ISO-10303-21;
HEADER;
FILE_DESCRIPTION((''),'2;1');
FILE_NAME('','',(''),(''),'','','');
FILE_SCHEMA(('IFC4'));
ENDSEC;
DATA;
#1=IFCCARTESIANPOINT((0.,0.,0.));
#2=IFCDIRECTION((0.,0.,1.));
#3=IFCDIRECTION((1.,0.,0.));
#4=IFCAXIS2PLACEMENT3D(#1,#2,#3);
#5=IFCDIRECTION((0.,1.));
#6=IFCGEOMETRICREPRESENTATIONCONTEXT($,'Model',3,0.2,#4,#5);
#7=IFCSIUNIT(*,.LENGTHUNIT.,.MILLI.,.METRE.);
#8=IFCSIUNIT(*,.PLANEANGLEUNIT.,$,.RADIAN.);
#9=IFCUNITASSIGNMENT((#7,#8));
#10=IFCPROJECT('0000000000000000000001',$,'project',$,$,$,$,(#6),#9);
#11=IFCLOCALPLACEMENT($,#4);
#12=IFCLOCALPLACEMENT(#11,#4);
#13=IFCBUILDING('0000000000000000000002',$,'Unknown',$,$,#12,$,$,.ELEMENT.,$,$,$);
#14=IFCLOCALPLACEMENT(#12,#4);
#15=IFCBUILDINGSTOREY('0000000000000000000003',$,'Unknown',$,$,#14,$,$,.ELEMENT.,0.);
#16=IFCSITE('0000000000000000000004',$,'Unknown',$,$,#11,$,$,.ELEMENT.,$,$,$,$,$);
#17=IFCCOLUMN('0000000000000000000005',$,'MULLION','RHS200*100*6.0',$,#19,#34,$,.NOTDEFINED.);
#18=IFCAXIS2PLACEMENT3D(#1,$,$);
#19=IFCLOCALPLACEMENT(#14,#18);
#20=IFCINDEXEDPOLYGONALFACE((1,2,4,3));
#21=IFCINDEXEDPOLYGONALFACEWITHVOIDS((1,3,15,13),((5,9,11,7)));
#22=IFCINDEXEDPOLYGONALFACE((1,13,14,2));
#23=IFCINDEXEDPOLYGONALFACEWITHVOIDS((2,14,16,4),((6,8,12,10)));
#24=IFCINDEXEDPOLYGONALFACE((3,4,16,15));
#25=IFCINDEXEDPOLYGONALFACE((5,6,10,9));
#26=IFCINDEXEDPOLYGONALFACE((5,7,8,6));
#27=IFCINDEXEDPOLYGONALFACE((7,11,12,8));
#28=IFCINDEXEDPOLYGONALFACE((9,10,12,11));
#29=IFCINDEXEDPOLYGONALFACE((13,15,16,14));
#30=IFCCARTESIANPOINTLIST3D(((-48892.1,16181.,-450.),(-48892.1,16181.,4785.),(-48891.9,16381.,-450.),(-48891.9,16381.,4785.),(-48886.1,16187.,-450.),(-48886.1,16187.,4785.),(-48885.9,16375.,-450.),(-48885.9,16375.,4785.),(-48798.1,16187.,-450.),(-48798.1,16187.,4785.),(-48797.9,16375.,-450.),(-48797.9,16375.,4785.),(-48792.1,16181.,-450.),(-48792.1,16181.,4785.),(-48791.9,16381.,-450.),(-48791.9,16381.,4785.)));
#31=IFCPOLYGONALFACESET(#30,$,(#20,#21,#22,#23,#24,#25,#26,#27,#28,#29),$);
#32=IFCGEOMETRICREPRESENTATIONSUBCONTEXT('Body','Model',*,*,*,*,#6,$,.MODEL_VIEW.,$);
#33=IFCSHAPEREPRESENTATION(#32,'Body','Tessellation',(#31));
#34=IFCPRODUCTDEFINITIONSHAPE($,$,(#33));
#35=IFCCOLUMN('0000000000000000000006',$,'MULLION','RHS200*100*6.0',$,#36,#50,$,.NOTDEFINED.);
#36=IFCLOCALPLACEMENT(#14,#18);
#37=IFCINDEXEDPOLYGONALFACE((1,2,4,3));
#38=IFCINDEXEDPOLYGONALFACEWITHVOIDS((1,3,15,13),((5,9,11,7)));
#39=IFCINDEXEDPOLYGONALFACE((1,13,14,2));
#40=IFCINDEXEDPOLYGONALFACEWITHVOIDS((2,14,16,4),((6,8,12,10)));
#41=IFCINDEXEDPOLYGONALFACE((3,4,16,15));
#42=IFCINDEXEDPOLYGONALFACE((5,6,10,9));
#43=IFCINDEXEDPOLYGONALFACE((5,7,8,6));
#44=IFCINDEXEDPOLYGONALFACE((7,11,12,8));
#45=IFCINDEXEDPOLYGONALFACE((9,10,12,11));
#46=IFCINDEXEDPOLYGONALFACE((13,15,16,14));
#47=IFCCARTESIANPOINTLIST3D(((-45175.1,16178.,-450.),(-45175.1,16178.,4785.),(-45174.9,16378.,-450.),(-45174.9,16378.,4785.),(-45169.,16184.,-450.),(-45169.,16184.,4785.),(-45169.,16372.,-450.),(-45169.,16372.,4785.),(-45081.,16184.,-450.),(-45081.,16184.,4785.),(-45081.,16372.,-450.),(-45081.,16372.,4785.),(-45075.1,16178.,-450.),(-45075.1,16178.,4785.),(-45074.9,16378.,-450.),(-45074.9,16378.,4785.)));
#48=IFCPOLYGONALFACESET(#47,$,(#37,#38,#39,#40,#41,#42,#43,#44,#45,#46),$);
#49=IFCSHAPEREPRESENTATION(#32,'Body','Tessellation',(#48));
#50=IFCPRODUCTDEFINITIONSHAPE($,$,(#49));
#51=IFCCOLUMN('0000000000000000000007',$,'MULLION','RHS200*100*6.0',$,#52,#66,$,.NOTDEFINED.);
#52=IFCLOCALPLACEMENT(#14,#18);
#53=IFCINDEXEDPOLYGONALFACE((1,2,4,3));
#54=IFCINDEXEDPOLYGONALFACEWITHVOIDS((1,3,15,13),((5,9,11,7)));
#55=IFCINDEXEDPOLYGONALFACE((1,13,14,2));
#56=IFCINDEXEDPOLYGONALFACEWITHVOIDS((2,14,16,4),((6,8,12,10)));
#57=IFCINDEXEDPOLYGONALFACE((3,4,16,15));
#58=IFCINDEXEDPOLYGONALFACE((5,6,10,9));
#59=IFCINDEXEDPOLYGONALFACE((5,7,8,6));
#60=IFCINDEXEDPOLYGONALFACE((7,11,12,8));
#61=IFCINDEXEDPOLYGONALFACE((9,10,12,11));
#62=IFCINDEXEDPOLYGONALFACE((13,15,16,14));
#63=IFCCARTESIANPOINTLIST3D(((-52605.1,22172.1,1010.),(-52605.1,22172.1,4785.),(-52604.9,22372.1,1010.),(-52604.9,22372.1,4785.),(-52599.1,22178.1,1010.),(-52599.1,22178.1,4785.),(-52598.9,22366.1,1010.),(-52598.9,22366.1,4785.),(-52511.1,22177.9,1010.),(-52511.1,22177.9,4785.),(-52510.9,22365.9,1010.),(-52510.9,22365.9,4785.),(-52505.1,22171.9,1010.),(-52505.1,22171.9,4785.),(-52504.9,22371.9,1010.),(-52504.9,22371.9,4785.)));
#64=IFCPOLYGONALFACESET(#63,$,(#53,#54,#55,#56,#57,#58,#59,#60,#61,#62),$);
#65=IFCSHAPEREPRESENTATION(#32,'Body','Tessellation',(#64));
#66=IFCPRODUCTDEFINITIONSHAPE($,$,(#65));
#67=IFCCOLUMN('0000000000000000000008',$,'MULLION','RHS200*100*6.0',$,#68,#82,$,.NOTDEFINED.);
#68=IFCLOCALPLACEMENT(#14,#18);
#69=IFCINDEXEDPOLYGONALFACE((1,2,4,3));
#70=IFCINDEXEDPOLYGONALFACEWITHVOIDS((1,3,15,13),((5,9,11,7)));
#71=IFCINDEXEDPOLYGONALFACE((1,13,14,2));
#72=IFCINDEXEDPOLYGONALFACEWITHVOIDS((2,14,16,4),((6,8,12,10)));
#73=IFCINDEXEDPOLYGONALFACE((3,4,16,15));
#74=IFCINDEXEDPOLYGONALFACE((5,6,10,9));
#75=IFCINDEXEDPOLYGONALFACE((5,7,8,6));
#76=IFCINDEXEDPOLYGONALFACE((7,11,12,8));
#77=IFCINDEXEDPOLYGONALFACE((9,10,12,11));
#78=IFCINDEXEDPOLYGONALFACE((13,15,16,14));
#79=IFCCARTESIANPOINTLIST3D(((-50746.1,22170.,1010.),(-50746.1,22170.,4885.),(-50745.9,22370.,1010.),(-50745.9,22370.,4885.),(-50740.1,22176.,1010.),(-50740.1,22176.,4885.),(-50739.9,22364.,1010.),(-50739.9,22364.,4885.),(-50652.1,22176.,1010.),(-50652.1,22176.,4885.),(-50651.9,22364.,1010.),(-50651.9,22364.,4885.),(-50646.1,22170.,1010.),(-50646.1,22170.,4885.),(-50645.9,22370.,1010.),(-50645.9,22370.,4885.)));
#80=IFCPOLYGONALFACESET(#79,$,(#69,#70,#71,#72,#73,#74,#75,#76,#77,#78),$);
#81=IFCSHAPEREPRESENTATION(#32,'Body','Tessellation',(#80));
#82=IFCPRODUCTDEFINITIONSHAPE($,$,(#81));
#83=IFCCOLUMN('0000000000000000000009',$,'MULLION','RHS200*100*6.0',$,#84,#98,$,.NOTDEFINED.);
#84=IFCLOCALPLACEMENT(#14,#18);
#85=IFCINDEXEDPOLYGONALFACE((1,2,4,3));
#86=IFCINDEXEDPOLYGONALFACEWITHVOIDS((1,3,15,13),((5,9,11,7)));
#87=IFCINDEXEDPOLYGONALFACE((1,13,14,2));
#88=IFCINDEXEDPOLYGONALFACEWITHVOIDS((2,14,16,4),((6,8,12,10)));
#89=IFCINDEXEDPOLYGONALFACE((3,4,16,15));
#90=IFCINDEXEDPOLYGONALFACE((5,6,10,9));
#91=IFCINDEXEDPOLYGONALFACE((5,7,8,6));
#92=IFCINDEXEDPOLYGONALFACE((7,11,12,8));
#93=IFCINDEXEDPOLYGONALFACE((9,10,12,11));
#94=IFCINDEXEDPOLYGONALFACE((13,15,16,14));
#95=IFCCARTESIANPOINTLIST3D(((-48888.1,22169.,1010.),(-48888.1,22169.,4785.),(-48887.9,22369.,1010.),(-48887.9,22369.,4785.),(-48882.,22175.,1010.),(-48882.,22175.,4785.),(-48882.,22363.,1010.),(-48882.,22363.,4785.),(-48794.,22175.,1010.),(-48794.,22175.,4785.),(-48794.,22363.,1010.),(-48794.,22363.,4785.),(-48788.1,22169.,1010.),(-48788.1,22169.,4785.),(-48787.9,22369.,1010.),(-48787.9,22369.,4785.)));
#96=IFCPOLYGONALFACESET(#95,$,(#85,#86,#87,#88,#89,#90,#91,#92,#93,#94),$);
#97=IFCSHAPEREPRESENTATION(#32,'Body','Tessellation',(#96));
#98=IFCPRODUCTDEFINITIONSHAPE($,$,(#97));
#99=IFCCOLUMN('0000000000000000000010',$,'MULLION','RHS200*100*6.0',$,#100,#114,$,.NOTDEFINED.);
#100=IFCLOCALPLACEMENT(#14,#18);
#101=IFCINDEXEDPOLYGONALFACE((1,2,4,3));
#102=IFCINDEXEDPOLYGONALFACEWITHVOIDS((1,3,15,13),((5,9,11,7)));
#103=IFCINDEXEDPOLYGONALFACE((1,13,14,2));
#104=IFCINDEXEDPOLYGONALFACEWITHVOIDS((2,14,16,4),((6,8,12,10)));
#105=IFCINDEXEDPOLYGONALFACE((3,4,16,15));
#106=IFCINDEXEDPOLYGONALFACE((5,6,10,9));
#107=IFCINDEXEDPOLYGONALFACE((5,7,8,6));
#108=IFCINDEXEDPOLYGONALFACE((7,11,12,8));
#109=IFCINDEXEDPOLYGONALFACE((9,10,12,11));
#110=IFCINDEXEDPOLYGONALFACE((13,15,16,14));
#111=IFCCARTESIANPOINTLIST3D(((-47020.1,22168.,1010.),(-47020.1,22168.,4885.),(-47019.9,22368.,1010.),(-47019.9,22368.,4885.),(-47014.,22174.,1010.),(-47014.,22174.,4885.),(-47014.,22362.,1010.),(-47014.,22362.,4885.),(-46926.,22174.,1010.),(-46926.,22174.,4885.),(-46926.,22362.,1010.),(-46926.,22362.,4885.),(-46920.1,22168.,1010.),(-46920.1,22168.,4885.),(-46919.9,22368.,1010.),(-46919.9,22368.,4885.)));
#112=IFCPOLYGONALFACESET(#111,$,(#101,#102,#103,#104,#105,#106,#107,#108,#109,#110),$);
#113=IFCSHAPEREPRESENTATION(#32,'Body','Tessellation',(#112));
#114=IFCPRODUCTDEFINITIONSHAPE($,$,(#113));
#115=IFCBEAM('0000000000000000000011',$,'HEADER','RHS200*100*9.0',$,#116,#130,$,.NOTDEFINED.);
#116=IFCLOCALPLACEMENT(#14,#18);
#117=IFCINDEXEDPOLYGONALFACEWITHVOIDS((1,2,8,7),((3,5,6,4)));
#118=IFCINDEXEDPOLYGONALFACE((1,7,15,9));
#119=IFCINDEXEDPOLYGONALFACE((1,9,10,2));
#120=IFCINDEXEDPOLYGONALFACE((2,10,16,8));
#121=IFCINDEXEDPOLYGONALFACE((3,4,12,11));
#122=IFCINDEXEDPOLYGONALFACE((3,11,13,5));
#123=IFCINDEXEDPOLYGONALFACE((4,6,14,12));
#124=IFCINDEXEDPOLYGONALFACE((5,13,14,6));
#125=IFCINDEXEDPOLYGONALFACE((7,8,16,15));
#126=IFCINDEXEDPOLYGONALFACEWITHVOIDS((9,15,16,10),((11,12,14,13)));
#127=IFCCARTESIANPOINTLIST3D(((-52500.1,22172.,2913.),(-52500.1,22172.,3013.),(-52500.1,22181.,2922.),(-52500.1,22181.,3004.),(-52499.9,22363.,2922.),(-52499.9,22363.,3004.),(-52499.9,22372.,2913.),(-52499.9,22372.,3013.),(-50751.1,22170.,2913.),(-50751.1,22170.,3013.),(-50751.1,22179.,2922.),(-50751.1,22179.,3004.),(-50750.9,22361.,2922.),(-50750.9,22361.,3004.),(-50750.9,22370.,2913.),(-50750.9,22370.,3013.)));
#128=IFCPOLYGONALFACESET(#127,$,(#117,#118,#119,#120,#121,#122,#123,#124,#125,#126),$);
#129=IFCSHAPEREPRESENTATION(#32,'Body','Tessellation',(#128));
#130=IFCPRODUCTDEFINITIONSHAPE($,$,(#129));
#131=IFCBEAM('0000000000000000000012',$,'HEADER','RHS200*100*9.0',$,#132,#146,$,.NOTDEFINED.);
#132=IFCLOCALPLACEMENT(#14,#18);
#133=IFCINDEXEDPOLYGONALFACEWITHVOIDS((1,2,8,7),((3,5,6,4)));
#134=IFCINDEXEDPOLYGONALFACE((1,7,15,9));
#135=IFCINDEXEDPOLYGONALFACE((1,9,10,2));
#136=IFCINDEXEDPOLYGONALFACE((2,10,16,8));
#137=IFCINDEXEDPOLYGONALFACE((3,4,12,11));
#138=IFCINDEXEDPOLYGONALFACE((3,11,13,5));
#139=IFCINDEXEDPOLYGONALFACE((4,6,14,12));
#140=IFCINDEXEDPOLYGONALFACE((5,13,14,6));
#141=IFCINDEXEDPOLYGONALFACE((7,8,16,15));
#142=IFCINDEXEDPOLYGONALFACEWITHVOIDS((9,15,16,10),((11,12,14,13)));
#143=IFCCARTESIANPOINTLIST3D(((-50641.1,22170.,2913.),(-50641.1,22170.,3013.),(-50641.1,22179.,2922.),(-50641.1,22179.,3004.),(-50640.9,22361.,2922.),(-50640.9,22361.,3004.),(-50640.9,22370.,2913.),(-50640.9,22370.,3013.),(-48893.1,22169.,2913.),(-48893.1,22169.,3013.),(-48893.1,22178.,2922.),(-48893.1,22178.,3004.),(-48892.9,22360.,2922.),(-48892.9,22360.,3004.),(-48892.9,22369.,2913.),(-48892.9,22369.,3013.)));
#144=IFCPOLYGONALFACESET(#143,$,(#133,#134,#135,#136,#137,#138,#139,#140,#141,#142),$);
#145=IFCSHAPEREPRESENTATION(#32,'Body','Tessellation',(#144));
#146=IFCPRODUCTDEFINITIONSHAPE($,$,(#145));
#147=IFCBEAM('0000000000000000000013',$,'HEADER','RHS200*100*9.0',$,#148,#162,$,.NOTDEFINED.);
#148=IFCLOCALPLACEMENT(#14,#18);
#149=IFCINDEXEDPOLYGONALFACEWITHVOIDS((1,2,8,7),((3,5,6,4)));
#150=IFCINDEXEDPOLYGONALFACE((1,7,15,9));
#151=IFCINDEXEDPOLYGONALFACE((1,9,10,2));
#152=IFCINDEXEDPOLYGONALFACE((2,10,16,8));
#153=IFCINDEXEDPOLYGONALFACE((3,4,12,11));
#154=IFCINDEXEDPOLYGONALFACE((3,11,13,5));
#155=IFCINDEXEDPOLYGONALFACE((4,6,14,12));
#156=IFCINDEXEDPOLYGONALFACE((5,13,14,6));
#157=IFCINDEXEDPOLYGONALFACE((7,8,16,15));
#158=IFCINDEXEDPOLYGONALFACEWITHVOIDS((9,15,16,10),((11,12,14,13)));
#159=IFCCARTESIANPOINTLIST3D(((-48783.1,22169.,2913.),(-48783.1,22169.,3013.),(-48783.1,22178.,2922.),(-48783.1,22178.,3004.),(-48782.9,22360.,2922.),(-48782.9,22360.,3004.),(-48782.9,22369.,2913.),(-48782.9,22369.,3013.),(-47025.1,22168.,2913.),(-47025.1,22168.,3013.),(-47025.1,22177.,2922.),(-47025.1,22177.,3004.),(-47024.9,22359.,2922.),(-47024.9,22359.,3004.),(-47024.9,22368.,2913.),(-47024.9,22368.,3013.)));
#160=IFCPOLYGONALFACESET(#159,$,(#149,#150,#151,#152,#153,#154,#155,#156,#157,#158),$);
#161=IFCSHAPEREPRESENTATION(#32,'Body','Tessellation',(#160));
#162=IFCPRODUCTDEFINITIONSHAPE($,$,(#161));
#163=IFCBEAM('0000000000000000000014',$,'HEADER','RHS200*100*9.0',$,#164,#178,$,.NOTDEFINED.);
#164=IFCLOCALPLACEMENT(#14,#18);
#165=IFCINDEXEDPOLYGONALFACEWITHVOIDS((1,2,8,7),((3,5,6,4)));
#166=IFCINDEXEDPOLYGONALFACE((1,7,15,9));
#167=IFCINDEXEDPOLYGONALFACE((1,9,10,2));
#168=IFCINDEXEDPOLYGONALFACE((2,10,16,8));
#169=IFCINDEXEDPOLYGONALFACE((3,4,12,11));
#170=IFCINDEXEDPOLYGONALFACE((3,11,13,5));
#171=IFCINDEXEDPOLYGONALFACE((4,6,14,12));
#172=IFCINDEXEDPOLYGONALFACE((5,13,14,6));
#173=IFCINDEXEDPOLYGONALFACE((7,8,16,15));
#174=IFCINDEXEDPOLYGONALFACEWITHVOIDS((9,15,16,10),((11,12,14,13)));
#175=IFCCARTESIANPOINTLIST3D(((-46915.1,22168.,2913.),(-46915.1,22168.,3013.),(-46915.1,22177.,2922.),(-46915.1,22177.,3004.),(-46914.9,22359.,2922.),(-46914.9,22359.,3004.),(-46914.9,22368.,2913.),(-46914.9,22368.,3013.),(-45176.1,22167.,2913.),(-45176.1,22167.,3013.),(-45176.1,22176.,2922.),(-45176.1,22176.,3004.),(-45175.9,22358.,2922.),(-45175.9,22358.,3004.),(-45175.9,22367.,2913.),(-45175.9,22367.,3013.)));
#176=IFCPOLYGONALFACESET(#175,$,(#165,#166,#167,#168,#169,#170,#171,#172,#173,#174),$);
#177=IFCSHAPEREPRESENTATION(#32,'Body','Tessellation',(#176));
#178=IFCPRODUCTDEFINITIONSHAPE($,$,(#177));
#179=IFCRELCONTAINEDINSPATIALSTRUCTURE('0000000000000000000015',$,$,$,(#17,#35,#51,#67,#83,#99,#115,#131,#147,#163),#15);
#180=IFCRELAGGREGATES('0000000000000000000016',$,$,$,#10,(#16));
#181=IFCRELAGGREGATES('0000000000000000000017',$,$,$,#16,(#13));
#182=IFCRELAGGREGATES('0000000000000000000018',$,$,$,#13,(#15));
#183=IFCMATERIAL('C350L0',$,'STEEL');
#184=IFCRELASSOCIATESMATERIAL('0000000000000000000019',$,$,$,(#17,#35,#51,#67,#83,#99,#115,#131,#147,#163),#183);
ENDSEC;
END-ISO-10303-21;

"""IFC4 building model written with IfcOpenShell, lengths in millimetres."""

from ifc_helpers import new_model, si_unit, direction, frame, origin_with_axes, place, context, subcontext, project, spatial, line, indexed_curve, outline, extrude, material, element, save


model = new_model("IFC4")

# Units and contexts
model_context = context("Model", 3, precision=0.2, world=origin_with_axes(), true_north=direction((0.0, 1.0)))
body_context = subcontext(model_context, "Body", "Model", "MODEL_VIEW")
ifc_project = project(units=[si_unit("LENGTHUNIT", "METRE", prefix="MILLI"), si_unit("PLANEANGLEUNIT", "RADIAN")], contexts=[model_context])

# Site, building, storey
site_placement = place(None, origin_with_axes())
site = spatial("IfcSite", under=ifc_project, at=site_placement, Name="Unknown", CompositionType="ELEMENT")
building_placement = place(site_placement, origin_with_axes())
building = spatial("IfcBuilding", under=site, at=building_placement, Name="Unknown", CompositionType="ELEMENT")
storey_placement = place(building_placement, origin_with_axes())
storey = spatial("IfcBuildingStorey", under=building, at=storey_placement, Name="Unknown", CompositionType="ELEMENT", Elevation=0.0)

# Columns
ifc_material_1 = material(Name="C350L0", Category="STEEL")
for number, where, z_axis, x_axis, name in (
    (1, (-48842.0, 16281.0, -450.0), (1.0, -0.000873, 0.0), (0.0, 0.0, 1.0), "MULLION"),
    (2, (-45125.0, 16278.0, -450.0), (1.0, -0.000524, 0.0), (0.0, 0.0, 1.0), "MULLION"),
):
    element("IfcColumn", number, at=place(storey_placement, frame(where, z_axis=z_axis, x_axis=x_axis)), inside=storey, material=ifc_material_1, Name=name, Description="RHS200*100*6.0", PredefinedType="NOTDEFINED", context=body_context, shape_type="SolidModel", body=[
        extrude(outline(indexed_curve([(-50.0, -100.0), (50.0, -100.0), (50.0, 100.0), (-50.0, 100.0)], segments=[line(1, 2, 3, 4, 1)]), holes=[indexed_curve([(-44.0, -94.0), (-44.0, 94.0), (44.0, 94.0), (44.0, -94.0)], segments=[line(1, 2, 3, 4, 1)])]), frame((0.0, 0.0, 0.0), z_axis=(-1.0, 0.0, 0.0), x_axis=(0.0, 0.0, 1.0)), (0.0, 0.0, -1.0), 5235.0),
    ])
column_1_placement = place(storey_placement, frame((-52555.0, 22272.0, 1010.0), z_axis=(0.999999, -0.001222, 0.0), x_axis=(0.0, 0.0, 1.0)))
element("IfcColumn", 3, at=column_1_placement, inside=storey, material=ifc_material_1, Name="MULLION", Description="RHS200*100*6.0", PredefinedType="NOTDEFINED", context=body_context, shape_type="SolidModel", body=[
    extrude(outline(indexed_curve([(-50.0, -100.0), (50.0, -100.0), (50.0, 100.0), (-50.0, 100.0)], segments=[line(1, 2, 3, 4, 1)]), holes=[indexed_curve([(-44.0, -94.0), (-44.0, 94.0), (44.0, 94.0), (44.0, -94.0)], segments=[line(1, 2, 3, 4, 1)])]), frame((0.0, 0.0, 0.0), z_axis=(-1.0, 0.0, 0.0), x_axis=(0.0, 0.0, 1.0)), (0.0, 0.0, -1.0), 3775.0),
])
column_2_placement = place(storey_placement, frame((-50696.0, 22270.0, 1010.0), z_axis=(1.0, -0.000873, 0.0), x_axis=(0.0, 0.0, 1.0)))
element("IfcColumn", 4, at=column_2_placement, inside=storey, material=ifc_material_1, Name="MULLION", Description="RHS200*100*6.0", PredefinedType="NOTDEFINED", context=body_context, shape_type="SolidModel", body=[
    extrude(outline(indexed_curve([(-50.0, -100.0), (50.0, -100.0), (50.0, 100.0), (-50.0, 100.0)], segments=[line(1, 2, 3, 4, 1)]), holes=[indexed_curve([(-44.0, -94.0), (-44.0, 94.0), (44.0, 94.0), (44.0, -94.0)], segments=[line(1, 2, 3, 4, 1)])]), frame((0.0, 0.0, 0.0), z_axis=(-1.0, 0.0, 0.0), x_axis=(0.0, 0.0, 1.0)), (0.0, 0.0, -1.0), 3875.0),
])
column_3_placement = place(storey_placement, frame((-48838.0, 22269.0, 1010.0), z_axis=(1.0, -0.000524, 0.0), x_axis=(0.0, 0.0, 1.0)))
element("IfcColumn", 5, at=column_3_placement, inside=storey, material=ifc_material_1, Name="MULLION", Description="RHS200*100*6.0", PredefinedType="NOTDEFINED", context=body_context, shape_type="SolidModel", body=[
    extrude(outline(indexed_curve([(-50.0, -100.0), (50.0, -100.0), (50.0, 100.0), (-50.0, 100.0)], segments=[line(1, 2, 3, 4, 1)]), holes=[indexed_curve([(-44.0, -94.0), (-44.0, 94.0), (44.0, 94.0), (44.0, -94.0)], segments=[line(1, 2, 3, 4, 1)])]), frame((0.0, 0.0, 0.0), z_axis=(-1.0, 0.0, 0.0), x_axis=(0.0, 0.0, 1.0)), (0.0, 0.0, -1.0), 3775.0),
])
column_4_placement = place(storey_placement, frame((-46970.0, 22268.0, 1010.0), z_axis=(1.0, -0.000524, 0.0), x_axis=(0.0, 0.0, 1.0)))
element("IfcColumn", 6, at=column_4_placement, inside=storey, material=ifc_material_1, Name="MULLION", Description="RHS200*100*6.0", PredefinedType="NOTDEFINED", context=body_context, shape_type="SolidModel", body=[
    extrude(outline(indexed_curve([(-50.0, -100.0), (50.0, -100.0), (50.0, 100.0), (-50.0, 100.0)], segments=[line(1, 2, 3, 4, 1)]), holes=[indexed_curve([(-44.0, -94.0), (-44.0, 94.0), (44.0, 94.0), (44.0, -94.0)], segments=[line(1, 2, 3, 4, 1)])]), frame((0.0, 0.0, 0.0), z_axis=(-1.0, 0.0, 0.0), x_axis=(0.0, 0.0, 1.0)), (0.0, 0.0, -1.0), 3875.0),
])

# Beams
beam_1_placement = place(storey_placement, frame((-50751.0, 22270.0, 2963.0), z_axis=(0.0, 0.0, 1.0), x_axis=(-0.999999, 0.001144, 0.0)))
element("IfcBeam", 7, at=beam_1_placement, inside=storey, material=ifc_material_1, Name="HEADER", Description="RHS200*100*9.0", PredefinedType="NOTDEFINED", context=body_context, shape_type="SolidModel", body=[
    extrude(outline(indexed_curve([(-50.0, -100.0), (50.0, -100.0), (50.0, 100.0), (-50.0, 100.0)], segments=[line(1, 2, 3, 4, 1)]), holes=[indexed_curve([(-41.0, -91.0), (-41.0, 91.0), (41.0, 91.0), (41.0, -91.0)], segments=[line(1, 2, 3, 4, 1)])]), frame((0.0, 0.0, 0.0), z_axis=(-1.0, 0.0, 0.0), x_axis=(0.0, 0.0, 1.0)), (0.0, 0.0, -1.0), 1749.0),
])
beam_2_placement = place(storey_placement, frame((-48893.0, 22269.0, 2963.0), z_axis=(0.0, 0.0, 1.0), x_axis=(-1.0, 0.000572, 0.0)))
element("IfcBeam", 8, at=beam_2_placement, inside=storey, material=ifc_material_1, Name="HEADER", Description="RHS200*100*9.0", PredefinedType="NOTDEFINED", context=body_context, shape_type="SolidModel", body=[
    extrude(outline(indexed_curve([(-50.0, -100.0), (50.0, -100.0), (50.0, 100.0), (-50.0, 100.0)], segments=[line(1, 2, 3, 4, 1)]), holes=[indexed_curve([(-41.0, -91.0), (-41.0, 91.0), (41.0, 91.0), (41.0, -91.0)], segments=[line(1, 2, 3, 4, 1)])]), frame((0.0, 0.0, 0.0), z_axis=(-1.0, 0.0, 0.0), x_axis=(0.0, 0.0, 1.0)), (0.0, 0.0, -1.0), 1748.0),
])
beam_3_placement = place(storey_placement, frame((-47025.0, 22268.0, 2963.0), z_axis=(0.0, 0.0, 1.0), x_axis=(-1.0, 0.000569, 0.0)))
element("IfcBeam", 9, at=beam_3_placement, inside=storey, material=ifc_material_1, Name="HEADER", Description="RHS200*100*9.0", PredefinedType="NOTDEFINED", context=body_context, shape_type="SolidModel", body=[
    extrude(outline(indexed_curve([(-50.0, -100.0), (50.0, -100.0), (50.0, 100.0), (-50.0, 100.0)], segments=[line(1, 2, 3, 4, 1)]), holes=[indexed_curve([(-41.0, -91.0), (-41.0, 91.0), (41.0, 91.0), (41.0, -91.0)], segments=[line(1, 2, 3, 4, 1)])]), frame((0.0, 0.0, 0.0), z_axis=(-1.0, 0.0, 0.0), x_axis=(0.0, 0.0, 1.0)), (0.0, 0.0, -1.0), 1758.0),
])
beam_4_placement = place(storey_placement, frame((-45176.0, 22267.0, 2963.0), z_axis=(0.0, 0.0, 1.0), x_axis=(-1.0, 0.000575, 0.0)))
element("IfcBeam", 10, at=beam_4_placement, inside=storey, material=ifc_material_1, Name="HEADER", Description="RHS200*100*9.0", PredefinedType="NOTDEFINED", context=body_context, shape_type="SolidModel", body=[
    extrude(outline(indexed_curve([(-50.0, -100.0), (50.0, -100.0), (50.0, 100.0), (-50.0, 100.0)], segments=[line(1, 2, 3, 4, 1)]), holes=[indexed_curve([(-41.0, -91.0), (-41.0, 91.0), (41.0, 91.0), (41.0, -91.0)], segments=[line(1, 2, 3, 4, 1)])]), frame((0.0, 0.0, 0.0), z_axis=(-1.0, 0.0, 0.0), x_axis=(0.0, 0.0, 1.0)), (0.0, 0.0, -1.0), 1739.0),
])

save(model, "model.ifc")
